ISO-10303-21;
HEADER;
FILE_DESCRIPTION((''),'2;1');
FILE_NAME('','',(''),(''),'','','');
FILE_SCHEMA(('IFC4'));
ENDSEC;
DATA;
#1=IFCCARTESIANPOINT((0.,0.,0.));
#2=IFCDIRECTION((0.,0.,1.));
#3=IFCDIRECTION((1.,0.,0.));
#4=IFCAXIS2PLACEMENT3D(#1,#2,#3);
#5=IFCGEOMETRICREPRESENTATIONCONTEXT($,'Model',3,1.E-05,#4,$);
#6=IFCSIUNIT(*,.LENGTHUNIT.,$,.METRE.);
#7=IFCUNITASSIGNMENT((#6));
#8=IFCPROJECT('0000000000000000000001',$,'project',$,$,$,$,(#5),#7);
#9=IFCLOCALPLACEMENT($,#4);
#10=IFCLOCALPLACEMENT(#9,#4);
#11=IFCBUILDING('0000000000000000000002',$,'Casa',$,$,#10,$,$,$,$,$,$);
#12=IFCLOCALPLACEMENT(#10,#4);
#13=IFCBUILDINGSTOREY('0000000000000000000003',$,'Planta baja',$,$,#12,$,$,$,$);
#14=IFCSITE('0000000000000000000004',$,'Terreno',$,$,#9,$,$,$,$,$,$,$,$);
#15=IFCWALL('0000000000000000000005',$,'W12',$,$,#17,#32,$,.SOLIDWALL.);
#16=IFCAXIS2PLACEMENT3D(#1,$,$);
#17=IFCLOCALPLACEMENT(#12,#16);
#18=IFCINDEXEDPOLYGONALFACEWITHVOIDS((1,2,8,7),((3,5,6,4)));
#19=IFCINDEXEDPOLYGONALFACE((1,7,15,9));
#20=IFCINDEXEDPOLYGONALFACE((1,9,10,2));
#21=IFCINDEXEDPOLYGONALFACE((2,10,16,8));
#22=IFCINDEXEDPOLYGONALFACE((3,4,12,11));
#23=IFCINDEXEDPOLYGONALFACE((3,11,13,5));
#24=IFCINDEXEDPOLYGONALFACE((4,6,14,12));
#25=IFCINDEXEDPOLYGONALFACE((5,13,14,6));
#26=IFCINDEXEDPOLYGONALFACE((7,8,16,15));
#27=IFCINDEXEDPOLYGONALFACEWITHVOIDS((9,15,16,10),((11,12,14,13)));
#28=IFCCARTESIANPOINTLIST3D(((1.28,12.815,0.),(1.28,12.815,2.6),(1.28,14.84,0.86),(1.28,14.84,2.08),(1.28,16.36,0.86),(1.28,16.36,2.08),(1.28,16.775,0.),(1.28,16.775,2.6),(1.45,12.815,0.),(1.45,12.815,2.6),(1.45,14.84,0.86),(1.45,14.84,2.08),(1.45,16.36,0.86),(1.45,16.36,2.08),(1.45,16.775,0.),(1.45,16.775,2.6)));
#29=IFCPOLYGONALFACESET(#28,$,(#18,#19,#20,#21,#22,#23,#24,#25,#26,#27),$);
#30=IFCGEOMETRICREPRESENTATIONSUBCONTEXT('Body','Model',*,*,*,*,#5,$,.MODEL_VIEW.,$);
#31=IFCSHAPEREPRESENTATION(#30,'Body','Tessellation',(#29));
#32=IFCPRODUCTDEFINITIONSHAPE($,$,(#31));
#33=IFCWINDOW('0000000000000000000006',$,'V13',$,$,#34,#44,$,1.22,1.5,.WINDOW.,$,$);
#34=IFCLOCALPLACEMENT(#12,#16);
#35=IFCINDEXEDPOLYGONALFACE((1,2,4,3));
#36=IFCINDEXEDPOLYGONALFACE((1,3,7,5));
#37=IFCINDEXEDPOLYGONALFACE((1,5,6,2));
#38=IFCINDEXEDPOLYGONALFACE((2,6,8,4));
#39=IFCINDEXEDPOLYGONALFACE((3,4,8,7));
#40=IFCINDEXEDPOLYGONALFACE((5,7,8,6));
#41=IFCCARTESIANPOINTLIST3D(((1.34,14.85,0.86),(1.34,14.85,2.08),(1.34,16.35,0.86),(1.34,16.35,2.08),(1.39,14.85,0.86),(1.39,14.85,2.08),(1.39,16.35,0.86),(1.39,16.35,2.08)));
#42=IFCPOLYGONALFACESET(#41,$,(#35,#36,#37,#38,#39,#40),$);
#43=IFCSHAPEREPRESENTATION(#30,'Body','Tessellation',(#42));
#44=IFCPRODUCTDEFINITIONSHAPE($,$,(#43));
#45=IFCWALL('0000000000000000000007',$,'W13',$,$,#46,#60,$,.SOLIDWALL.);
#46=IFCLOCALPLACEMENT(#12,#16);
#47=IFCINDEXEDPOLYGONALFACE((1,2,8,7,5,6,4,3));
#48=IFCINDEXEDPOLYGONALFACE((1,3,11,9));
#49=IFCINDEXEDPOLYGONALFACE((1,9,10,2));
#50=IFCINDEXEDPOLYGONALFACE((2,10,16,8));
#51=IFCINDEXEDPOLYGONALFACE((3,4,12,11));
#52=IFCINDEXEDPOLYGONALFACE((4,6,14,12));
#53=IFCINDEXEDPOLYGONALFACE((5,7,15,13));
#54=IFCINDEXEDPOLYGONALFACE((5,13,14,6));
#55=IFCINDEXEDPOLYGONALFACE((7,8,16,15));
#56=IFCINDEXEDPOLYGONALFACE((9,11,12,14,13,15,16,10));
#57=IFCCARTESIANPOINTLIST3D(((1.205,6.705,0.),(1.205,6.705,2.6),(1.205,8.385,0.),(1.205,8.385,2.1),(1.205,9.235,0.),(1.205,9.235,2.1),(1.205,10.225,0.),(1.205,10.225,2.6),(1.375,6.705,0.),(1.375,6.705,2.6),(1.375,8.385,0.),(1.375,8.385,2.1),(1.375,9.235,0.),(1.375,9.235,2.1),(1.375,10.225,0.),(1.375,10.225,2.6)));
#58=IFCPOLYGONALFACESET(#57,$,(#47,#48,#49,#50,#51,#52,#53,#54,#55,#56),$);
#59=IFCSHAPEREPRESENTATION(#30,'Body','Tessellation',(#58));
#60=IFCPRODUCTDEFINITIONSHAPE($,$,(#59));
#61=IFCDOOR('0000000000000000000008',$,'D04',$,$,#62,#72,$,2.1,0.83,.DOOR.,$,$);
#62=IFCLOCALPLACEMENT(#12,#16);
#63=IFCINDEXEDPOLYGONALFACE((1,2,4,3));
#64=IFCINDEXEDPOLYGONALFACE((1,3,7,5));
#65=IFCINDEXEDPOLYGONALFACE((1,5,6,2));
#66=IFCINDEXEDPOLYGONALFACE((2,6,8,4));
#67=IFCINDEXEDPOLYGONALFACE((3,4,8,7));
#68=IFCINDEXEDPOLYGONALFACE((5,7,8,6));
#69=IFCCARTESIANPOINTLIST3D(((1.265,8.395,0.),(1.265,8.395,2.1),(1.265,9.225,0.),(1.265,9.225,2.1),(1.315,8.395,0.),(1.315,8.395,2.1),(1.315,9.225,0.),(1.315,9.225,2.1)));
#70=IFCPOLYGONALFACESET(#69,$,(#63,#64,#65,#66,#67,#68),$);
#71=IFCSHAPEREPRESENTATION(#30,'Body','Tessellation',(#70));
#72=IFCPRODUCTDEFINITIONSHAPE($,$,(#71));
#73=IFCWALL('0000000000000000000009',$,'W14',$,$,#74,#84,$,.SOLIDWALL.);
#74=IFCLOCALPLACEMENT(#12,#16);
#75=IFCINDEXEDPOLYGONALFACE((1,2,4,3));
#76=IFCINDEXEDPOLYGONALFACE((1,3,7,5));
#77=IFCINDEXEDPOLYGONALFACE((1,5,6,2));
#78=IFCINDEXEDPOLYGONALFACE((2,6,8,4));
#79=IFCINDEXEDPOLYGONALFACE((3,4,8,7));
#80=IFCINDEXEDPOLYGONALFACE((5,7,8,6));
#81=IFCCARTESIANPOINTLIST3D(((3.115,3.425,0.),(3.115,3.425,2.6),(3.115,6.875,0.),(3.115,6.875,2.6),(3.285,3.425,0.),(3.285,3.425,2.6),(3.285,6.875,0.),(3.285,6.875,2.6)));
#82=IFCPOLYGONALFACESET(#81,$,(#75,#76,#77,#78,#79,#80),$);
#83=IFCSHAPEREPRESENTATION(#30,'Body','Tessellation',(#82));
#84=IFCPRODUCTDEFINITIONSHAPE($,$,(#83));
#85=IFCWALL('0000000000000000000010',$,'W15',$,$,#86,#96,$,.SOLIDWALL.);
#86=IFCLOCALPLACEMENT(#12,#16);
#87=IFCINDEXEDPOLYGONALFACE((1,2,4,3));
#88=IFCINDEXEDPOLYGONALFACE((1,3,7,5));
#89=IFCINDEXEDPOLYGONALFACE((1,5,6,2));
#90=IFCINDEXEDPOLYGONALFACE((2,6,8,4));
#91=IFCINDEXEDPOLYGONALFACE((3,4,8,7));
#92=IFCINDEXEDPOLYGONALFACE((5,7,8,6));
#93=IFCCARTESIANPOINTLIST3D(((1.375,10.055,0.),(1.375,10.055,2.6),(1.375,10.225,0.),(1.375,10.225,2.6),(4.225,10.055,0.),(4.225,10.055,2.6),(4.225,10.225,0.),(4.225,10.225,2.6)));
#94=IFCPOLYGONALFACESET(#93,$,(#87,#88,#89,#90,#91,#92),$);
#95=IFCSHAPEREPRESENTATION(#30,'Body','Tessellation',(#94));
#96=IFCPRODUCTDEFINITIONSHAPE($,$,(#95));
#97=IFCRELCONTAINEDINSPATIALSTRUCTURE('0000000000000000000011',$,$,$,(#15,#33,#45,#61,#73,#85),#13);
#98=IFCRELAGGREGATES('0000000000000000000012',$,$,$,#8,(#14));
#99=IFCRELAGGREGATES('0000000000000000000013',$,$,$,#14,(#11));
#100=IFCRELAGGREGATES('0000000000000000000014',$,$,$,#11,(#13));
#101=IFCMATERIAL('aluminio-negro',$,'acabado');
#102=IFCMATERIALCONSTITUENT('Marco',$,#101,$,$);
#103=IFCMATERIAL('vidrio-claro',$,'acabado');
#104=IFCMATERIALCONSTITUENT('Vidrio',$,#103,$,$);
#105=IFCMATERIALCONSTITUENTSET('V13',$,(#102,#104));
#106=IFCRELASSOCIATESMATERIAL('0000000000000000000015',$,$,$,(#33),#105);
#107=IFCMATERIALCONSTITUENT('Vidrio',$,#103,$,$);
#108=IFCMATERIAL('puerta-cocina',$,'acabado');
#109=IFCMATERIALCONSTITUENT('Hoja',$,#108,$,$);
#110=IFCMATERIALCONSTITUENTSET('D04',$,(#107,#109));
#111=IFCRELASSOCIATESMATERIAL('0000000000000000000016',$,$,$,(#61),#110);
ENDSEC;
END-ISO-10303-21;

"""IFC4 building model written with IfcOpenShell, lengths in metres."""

from ifc_helpers import new_model, si_unit, frame, origin_with_axes, place, context, subcontext, project, spatial, line, indexed_curve, outline, extrude, material, constituent, constituent_set, element, fill, save


model = new_model("IFC4")

# Units and contexts
model_context = context("Model", 3, precision=1e-05, world=origin_with_axes())
body_context = subcontext(model_context, "Body", "Model", "MODEL_VIEW")
ifc_project = project(units=[si_unit("LENGTHUNIT", "METRE")], contexts=[model_context])

# Site, building, storey
site_placement = place(None, origin_with_axes())
site = spatial("IfcSite", under=ifc_project, at=site_placement, Name="Terreno")
building_placement = place(site_placement, origin_with_axes())
building = spatial("IfcBuilding", under=site, at=building_placement, Name="Casa")
storey_placement = place(building_placement, origin_with_axes())
storey = spatial("IfcBuildingStorey", under=building, at=storey_placement, Name="Planta baja")

# Shared definitions
ifc_material_1 = material(Name="aluminio-negro", Category="acabado")
ifc_material_2 = material(Name="vidrio-claro", Category="acabado")

# Wall, opening, window
wall_1_placement = place(storey_placement, origin_with_axes())
wall_1 = element("IfcWall", 1, at=wall_1_placement, inside=storey, Name="W12", PredefinedType="SOLIDWALL", context=body_context, shape_type="SweptSolid", body=[
    extrude(outline(indexed_curve([(1.28, 16.775), (1.45, 16.775), (1.45, 12.815), (1.28, 12.815)], segments=[line(1, 2, 3, 4, 1)])), origin_with_axes(), (0.0, 0.0, 1.0), 2.6),
])
opening_1_placement = place(wall_1_placement, origin_with_axes())
opening_1 = element("IfcOpeningElement", 2, at=opening_1_placement, cuts=wall_1, PredefinedType="OPENING", context=body_context, shape_type="SweptSolid", body=[
    extrude(outline(indexed_curve([(1.27, 14.84), (1.46, 14.84), (1.46, 16.36), (1.27, 16.36)], segments=[line(1, 2, 3, 4, 1)])), frame((0.0, 0.0, 0.86), z_axis=(0.0, 0.0, 1.0), x_axis=(1.0, 0.0, 0.0)), (0.0, 0.0, 1.0), 1.22),
])
ifc_constituent_1 = constituent(ifc_material_1, Name="Marco")
ifc_constituent_2 = constituent(ifc_material_2, Name="Vidrio")
ifc_constituent_set_1 = constituent_set(constituents=[ifc_constituent_1, ifc_constituent_2], Name="V13")
window_1_placement = place(opening_1_placement, origin_with_axes())
window_1 = element("IfcWindow", 3, at=window_1_placement, inside=storey, material=ifc_constituent_set_1, Name="V13", OverallHeight=1.22, OverallWidth=1.5, PredefinedType="WINDOW", context=body_context, shape_type="SweptSolid", body=[
    extrude(outline(indexed_curve([(1.34, 14.85), (1.34, 16.35), (1.39, 16.35), (1.39, 14.85)], segments=[line(1, 2, 3, 4, 1)])), frame((0.0, 0.0, 0.86), z_axis=(0.0, 0.0, 1.0), x_axis=(1.0, 0.0, 0.0)), (0.0, 0.0, 1.0), 1.22),
])
fill(opening_1, window_1)

# Wall, opening, door
wall_2_placement = place(storey_placement, origin_with_axes())
wall_2 = element("IfcWall", 4, at=wall_2_placement, inside=storey, Name="W13", PredefinedType="SOLIDWALL", context=body_context, shape_type="SweptSolid", body=[
    extrude(outline(indexed_curve([(1.375, 6.705), (1.205, 6.705), (1.205, 10.225), (1.375, 10.225)], segments=[line(1, 2, 3, 4, 1)])), origin_with_axes(), (0.0, 0.0, 1.0), 2.6),
])
opening_2_placement = place(wall_2_placement, origin_with_axes())
opening_2 = element("IfcOpeningElement", 5, at=opening_2_placement, cuts=wall_2, PredefinedType="OPENING", context=body_context, shape_type="SweptSolid", body=[
    extrude(outline(indexed_curve([(1.195, 8.385), (1.195, 9.235), (1.385, 9.235), (1.385, 8.385)], segments=[line(1, 2, 3, 4, 1)])), origin_with_axes(), (0.0, 0.0, 1.0), 2.1),
])
ifc_constituent_3 = constituent(ifc_material_2, Name="Vidrio")
ifc_material_3 = material(Name="puerta-cocina", Category="acabado")
ifc_constituent_4 = constituent(ifc_material_3, Name="Hoja")
ifc_constituent_set_2 = constituent_set(constituents=[ifc_constituent_3, ifc_constituent_4], Name="D04")
door_1_placement = place(opening_2_placement, origin_with_axes())
door_1 = element("IfcDoor", 6, at=door_1_placement, inside=storey, material=ifc_constituent_set_2, Name="D04", OverallHeight=2.1, OverallWidth=0.83, PredefinedType="DOOR", context=body_context, shape_type="SweptSolid", body=[
    extrude(outline(indexed_curve([(1.265, 8.395), (1.265, 9.225), (1.315, 9.225), (1.315, 8.395)], segments=[line(1, 2, 3, 4, 1)])), origin_with_axes(), (0.0, 0.0, 1.0), 2.1),
])
fill(opening_2, door_1)

# Walls
wall_3_placement = place(storey_placement, origin_with_axes())
element("IfcWall", 7, at=wall_3_placement, inside=storey, Name="W14", PredefinedType="SOLIDWALL", context=body_context, shape_type="SweptSolid", body=[
    extrude(outline(indexed_curve([(3.285, 3.425), (3.115, 3.425), (3.115, 6.875), (3.285, 6.875)], segments=[line(1, 2, 3, 4, 1)])), origin_with_axes(), (0.0, 0.0, 1.0), 2.6),
])
wall_4_placement = place(storey_placement, origin_with_axes())
element("IfcWall", 8, at=wall_4_placement, inside=storey, Name="W15", PredefinedType="SOLIDWALL", context=body_context, shape_type="SweptSolid", body=[
    extrude(outline(indexed_curve([(4.225, 10.225), (4.225, 10.055), (1.375, 10.055), (1.375, 10.225)], segments=[line(1, 2, 3, 4, 1)])), origin_with_axes(), (0.0, 0.0, 1.0), 2.6),
])

save(model, "model.ifc")
